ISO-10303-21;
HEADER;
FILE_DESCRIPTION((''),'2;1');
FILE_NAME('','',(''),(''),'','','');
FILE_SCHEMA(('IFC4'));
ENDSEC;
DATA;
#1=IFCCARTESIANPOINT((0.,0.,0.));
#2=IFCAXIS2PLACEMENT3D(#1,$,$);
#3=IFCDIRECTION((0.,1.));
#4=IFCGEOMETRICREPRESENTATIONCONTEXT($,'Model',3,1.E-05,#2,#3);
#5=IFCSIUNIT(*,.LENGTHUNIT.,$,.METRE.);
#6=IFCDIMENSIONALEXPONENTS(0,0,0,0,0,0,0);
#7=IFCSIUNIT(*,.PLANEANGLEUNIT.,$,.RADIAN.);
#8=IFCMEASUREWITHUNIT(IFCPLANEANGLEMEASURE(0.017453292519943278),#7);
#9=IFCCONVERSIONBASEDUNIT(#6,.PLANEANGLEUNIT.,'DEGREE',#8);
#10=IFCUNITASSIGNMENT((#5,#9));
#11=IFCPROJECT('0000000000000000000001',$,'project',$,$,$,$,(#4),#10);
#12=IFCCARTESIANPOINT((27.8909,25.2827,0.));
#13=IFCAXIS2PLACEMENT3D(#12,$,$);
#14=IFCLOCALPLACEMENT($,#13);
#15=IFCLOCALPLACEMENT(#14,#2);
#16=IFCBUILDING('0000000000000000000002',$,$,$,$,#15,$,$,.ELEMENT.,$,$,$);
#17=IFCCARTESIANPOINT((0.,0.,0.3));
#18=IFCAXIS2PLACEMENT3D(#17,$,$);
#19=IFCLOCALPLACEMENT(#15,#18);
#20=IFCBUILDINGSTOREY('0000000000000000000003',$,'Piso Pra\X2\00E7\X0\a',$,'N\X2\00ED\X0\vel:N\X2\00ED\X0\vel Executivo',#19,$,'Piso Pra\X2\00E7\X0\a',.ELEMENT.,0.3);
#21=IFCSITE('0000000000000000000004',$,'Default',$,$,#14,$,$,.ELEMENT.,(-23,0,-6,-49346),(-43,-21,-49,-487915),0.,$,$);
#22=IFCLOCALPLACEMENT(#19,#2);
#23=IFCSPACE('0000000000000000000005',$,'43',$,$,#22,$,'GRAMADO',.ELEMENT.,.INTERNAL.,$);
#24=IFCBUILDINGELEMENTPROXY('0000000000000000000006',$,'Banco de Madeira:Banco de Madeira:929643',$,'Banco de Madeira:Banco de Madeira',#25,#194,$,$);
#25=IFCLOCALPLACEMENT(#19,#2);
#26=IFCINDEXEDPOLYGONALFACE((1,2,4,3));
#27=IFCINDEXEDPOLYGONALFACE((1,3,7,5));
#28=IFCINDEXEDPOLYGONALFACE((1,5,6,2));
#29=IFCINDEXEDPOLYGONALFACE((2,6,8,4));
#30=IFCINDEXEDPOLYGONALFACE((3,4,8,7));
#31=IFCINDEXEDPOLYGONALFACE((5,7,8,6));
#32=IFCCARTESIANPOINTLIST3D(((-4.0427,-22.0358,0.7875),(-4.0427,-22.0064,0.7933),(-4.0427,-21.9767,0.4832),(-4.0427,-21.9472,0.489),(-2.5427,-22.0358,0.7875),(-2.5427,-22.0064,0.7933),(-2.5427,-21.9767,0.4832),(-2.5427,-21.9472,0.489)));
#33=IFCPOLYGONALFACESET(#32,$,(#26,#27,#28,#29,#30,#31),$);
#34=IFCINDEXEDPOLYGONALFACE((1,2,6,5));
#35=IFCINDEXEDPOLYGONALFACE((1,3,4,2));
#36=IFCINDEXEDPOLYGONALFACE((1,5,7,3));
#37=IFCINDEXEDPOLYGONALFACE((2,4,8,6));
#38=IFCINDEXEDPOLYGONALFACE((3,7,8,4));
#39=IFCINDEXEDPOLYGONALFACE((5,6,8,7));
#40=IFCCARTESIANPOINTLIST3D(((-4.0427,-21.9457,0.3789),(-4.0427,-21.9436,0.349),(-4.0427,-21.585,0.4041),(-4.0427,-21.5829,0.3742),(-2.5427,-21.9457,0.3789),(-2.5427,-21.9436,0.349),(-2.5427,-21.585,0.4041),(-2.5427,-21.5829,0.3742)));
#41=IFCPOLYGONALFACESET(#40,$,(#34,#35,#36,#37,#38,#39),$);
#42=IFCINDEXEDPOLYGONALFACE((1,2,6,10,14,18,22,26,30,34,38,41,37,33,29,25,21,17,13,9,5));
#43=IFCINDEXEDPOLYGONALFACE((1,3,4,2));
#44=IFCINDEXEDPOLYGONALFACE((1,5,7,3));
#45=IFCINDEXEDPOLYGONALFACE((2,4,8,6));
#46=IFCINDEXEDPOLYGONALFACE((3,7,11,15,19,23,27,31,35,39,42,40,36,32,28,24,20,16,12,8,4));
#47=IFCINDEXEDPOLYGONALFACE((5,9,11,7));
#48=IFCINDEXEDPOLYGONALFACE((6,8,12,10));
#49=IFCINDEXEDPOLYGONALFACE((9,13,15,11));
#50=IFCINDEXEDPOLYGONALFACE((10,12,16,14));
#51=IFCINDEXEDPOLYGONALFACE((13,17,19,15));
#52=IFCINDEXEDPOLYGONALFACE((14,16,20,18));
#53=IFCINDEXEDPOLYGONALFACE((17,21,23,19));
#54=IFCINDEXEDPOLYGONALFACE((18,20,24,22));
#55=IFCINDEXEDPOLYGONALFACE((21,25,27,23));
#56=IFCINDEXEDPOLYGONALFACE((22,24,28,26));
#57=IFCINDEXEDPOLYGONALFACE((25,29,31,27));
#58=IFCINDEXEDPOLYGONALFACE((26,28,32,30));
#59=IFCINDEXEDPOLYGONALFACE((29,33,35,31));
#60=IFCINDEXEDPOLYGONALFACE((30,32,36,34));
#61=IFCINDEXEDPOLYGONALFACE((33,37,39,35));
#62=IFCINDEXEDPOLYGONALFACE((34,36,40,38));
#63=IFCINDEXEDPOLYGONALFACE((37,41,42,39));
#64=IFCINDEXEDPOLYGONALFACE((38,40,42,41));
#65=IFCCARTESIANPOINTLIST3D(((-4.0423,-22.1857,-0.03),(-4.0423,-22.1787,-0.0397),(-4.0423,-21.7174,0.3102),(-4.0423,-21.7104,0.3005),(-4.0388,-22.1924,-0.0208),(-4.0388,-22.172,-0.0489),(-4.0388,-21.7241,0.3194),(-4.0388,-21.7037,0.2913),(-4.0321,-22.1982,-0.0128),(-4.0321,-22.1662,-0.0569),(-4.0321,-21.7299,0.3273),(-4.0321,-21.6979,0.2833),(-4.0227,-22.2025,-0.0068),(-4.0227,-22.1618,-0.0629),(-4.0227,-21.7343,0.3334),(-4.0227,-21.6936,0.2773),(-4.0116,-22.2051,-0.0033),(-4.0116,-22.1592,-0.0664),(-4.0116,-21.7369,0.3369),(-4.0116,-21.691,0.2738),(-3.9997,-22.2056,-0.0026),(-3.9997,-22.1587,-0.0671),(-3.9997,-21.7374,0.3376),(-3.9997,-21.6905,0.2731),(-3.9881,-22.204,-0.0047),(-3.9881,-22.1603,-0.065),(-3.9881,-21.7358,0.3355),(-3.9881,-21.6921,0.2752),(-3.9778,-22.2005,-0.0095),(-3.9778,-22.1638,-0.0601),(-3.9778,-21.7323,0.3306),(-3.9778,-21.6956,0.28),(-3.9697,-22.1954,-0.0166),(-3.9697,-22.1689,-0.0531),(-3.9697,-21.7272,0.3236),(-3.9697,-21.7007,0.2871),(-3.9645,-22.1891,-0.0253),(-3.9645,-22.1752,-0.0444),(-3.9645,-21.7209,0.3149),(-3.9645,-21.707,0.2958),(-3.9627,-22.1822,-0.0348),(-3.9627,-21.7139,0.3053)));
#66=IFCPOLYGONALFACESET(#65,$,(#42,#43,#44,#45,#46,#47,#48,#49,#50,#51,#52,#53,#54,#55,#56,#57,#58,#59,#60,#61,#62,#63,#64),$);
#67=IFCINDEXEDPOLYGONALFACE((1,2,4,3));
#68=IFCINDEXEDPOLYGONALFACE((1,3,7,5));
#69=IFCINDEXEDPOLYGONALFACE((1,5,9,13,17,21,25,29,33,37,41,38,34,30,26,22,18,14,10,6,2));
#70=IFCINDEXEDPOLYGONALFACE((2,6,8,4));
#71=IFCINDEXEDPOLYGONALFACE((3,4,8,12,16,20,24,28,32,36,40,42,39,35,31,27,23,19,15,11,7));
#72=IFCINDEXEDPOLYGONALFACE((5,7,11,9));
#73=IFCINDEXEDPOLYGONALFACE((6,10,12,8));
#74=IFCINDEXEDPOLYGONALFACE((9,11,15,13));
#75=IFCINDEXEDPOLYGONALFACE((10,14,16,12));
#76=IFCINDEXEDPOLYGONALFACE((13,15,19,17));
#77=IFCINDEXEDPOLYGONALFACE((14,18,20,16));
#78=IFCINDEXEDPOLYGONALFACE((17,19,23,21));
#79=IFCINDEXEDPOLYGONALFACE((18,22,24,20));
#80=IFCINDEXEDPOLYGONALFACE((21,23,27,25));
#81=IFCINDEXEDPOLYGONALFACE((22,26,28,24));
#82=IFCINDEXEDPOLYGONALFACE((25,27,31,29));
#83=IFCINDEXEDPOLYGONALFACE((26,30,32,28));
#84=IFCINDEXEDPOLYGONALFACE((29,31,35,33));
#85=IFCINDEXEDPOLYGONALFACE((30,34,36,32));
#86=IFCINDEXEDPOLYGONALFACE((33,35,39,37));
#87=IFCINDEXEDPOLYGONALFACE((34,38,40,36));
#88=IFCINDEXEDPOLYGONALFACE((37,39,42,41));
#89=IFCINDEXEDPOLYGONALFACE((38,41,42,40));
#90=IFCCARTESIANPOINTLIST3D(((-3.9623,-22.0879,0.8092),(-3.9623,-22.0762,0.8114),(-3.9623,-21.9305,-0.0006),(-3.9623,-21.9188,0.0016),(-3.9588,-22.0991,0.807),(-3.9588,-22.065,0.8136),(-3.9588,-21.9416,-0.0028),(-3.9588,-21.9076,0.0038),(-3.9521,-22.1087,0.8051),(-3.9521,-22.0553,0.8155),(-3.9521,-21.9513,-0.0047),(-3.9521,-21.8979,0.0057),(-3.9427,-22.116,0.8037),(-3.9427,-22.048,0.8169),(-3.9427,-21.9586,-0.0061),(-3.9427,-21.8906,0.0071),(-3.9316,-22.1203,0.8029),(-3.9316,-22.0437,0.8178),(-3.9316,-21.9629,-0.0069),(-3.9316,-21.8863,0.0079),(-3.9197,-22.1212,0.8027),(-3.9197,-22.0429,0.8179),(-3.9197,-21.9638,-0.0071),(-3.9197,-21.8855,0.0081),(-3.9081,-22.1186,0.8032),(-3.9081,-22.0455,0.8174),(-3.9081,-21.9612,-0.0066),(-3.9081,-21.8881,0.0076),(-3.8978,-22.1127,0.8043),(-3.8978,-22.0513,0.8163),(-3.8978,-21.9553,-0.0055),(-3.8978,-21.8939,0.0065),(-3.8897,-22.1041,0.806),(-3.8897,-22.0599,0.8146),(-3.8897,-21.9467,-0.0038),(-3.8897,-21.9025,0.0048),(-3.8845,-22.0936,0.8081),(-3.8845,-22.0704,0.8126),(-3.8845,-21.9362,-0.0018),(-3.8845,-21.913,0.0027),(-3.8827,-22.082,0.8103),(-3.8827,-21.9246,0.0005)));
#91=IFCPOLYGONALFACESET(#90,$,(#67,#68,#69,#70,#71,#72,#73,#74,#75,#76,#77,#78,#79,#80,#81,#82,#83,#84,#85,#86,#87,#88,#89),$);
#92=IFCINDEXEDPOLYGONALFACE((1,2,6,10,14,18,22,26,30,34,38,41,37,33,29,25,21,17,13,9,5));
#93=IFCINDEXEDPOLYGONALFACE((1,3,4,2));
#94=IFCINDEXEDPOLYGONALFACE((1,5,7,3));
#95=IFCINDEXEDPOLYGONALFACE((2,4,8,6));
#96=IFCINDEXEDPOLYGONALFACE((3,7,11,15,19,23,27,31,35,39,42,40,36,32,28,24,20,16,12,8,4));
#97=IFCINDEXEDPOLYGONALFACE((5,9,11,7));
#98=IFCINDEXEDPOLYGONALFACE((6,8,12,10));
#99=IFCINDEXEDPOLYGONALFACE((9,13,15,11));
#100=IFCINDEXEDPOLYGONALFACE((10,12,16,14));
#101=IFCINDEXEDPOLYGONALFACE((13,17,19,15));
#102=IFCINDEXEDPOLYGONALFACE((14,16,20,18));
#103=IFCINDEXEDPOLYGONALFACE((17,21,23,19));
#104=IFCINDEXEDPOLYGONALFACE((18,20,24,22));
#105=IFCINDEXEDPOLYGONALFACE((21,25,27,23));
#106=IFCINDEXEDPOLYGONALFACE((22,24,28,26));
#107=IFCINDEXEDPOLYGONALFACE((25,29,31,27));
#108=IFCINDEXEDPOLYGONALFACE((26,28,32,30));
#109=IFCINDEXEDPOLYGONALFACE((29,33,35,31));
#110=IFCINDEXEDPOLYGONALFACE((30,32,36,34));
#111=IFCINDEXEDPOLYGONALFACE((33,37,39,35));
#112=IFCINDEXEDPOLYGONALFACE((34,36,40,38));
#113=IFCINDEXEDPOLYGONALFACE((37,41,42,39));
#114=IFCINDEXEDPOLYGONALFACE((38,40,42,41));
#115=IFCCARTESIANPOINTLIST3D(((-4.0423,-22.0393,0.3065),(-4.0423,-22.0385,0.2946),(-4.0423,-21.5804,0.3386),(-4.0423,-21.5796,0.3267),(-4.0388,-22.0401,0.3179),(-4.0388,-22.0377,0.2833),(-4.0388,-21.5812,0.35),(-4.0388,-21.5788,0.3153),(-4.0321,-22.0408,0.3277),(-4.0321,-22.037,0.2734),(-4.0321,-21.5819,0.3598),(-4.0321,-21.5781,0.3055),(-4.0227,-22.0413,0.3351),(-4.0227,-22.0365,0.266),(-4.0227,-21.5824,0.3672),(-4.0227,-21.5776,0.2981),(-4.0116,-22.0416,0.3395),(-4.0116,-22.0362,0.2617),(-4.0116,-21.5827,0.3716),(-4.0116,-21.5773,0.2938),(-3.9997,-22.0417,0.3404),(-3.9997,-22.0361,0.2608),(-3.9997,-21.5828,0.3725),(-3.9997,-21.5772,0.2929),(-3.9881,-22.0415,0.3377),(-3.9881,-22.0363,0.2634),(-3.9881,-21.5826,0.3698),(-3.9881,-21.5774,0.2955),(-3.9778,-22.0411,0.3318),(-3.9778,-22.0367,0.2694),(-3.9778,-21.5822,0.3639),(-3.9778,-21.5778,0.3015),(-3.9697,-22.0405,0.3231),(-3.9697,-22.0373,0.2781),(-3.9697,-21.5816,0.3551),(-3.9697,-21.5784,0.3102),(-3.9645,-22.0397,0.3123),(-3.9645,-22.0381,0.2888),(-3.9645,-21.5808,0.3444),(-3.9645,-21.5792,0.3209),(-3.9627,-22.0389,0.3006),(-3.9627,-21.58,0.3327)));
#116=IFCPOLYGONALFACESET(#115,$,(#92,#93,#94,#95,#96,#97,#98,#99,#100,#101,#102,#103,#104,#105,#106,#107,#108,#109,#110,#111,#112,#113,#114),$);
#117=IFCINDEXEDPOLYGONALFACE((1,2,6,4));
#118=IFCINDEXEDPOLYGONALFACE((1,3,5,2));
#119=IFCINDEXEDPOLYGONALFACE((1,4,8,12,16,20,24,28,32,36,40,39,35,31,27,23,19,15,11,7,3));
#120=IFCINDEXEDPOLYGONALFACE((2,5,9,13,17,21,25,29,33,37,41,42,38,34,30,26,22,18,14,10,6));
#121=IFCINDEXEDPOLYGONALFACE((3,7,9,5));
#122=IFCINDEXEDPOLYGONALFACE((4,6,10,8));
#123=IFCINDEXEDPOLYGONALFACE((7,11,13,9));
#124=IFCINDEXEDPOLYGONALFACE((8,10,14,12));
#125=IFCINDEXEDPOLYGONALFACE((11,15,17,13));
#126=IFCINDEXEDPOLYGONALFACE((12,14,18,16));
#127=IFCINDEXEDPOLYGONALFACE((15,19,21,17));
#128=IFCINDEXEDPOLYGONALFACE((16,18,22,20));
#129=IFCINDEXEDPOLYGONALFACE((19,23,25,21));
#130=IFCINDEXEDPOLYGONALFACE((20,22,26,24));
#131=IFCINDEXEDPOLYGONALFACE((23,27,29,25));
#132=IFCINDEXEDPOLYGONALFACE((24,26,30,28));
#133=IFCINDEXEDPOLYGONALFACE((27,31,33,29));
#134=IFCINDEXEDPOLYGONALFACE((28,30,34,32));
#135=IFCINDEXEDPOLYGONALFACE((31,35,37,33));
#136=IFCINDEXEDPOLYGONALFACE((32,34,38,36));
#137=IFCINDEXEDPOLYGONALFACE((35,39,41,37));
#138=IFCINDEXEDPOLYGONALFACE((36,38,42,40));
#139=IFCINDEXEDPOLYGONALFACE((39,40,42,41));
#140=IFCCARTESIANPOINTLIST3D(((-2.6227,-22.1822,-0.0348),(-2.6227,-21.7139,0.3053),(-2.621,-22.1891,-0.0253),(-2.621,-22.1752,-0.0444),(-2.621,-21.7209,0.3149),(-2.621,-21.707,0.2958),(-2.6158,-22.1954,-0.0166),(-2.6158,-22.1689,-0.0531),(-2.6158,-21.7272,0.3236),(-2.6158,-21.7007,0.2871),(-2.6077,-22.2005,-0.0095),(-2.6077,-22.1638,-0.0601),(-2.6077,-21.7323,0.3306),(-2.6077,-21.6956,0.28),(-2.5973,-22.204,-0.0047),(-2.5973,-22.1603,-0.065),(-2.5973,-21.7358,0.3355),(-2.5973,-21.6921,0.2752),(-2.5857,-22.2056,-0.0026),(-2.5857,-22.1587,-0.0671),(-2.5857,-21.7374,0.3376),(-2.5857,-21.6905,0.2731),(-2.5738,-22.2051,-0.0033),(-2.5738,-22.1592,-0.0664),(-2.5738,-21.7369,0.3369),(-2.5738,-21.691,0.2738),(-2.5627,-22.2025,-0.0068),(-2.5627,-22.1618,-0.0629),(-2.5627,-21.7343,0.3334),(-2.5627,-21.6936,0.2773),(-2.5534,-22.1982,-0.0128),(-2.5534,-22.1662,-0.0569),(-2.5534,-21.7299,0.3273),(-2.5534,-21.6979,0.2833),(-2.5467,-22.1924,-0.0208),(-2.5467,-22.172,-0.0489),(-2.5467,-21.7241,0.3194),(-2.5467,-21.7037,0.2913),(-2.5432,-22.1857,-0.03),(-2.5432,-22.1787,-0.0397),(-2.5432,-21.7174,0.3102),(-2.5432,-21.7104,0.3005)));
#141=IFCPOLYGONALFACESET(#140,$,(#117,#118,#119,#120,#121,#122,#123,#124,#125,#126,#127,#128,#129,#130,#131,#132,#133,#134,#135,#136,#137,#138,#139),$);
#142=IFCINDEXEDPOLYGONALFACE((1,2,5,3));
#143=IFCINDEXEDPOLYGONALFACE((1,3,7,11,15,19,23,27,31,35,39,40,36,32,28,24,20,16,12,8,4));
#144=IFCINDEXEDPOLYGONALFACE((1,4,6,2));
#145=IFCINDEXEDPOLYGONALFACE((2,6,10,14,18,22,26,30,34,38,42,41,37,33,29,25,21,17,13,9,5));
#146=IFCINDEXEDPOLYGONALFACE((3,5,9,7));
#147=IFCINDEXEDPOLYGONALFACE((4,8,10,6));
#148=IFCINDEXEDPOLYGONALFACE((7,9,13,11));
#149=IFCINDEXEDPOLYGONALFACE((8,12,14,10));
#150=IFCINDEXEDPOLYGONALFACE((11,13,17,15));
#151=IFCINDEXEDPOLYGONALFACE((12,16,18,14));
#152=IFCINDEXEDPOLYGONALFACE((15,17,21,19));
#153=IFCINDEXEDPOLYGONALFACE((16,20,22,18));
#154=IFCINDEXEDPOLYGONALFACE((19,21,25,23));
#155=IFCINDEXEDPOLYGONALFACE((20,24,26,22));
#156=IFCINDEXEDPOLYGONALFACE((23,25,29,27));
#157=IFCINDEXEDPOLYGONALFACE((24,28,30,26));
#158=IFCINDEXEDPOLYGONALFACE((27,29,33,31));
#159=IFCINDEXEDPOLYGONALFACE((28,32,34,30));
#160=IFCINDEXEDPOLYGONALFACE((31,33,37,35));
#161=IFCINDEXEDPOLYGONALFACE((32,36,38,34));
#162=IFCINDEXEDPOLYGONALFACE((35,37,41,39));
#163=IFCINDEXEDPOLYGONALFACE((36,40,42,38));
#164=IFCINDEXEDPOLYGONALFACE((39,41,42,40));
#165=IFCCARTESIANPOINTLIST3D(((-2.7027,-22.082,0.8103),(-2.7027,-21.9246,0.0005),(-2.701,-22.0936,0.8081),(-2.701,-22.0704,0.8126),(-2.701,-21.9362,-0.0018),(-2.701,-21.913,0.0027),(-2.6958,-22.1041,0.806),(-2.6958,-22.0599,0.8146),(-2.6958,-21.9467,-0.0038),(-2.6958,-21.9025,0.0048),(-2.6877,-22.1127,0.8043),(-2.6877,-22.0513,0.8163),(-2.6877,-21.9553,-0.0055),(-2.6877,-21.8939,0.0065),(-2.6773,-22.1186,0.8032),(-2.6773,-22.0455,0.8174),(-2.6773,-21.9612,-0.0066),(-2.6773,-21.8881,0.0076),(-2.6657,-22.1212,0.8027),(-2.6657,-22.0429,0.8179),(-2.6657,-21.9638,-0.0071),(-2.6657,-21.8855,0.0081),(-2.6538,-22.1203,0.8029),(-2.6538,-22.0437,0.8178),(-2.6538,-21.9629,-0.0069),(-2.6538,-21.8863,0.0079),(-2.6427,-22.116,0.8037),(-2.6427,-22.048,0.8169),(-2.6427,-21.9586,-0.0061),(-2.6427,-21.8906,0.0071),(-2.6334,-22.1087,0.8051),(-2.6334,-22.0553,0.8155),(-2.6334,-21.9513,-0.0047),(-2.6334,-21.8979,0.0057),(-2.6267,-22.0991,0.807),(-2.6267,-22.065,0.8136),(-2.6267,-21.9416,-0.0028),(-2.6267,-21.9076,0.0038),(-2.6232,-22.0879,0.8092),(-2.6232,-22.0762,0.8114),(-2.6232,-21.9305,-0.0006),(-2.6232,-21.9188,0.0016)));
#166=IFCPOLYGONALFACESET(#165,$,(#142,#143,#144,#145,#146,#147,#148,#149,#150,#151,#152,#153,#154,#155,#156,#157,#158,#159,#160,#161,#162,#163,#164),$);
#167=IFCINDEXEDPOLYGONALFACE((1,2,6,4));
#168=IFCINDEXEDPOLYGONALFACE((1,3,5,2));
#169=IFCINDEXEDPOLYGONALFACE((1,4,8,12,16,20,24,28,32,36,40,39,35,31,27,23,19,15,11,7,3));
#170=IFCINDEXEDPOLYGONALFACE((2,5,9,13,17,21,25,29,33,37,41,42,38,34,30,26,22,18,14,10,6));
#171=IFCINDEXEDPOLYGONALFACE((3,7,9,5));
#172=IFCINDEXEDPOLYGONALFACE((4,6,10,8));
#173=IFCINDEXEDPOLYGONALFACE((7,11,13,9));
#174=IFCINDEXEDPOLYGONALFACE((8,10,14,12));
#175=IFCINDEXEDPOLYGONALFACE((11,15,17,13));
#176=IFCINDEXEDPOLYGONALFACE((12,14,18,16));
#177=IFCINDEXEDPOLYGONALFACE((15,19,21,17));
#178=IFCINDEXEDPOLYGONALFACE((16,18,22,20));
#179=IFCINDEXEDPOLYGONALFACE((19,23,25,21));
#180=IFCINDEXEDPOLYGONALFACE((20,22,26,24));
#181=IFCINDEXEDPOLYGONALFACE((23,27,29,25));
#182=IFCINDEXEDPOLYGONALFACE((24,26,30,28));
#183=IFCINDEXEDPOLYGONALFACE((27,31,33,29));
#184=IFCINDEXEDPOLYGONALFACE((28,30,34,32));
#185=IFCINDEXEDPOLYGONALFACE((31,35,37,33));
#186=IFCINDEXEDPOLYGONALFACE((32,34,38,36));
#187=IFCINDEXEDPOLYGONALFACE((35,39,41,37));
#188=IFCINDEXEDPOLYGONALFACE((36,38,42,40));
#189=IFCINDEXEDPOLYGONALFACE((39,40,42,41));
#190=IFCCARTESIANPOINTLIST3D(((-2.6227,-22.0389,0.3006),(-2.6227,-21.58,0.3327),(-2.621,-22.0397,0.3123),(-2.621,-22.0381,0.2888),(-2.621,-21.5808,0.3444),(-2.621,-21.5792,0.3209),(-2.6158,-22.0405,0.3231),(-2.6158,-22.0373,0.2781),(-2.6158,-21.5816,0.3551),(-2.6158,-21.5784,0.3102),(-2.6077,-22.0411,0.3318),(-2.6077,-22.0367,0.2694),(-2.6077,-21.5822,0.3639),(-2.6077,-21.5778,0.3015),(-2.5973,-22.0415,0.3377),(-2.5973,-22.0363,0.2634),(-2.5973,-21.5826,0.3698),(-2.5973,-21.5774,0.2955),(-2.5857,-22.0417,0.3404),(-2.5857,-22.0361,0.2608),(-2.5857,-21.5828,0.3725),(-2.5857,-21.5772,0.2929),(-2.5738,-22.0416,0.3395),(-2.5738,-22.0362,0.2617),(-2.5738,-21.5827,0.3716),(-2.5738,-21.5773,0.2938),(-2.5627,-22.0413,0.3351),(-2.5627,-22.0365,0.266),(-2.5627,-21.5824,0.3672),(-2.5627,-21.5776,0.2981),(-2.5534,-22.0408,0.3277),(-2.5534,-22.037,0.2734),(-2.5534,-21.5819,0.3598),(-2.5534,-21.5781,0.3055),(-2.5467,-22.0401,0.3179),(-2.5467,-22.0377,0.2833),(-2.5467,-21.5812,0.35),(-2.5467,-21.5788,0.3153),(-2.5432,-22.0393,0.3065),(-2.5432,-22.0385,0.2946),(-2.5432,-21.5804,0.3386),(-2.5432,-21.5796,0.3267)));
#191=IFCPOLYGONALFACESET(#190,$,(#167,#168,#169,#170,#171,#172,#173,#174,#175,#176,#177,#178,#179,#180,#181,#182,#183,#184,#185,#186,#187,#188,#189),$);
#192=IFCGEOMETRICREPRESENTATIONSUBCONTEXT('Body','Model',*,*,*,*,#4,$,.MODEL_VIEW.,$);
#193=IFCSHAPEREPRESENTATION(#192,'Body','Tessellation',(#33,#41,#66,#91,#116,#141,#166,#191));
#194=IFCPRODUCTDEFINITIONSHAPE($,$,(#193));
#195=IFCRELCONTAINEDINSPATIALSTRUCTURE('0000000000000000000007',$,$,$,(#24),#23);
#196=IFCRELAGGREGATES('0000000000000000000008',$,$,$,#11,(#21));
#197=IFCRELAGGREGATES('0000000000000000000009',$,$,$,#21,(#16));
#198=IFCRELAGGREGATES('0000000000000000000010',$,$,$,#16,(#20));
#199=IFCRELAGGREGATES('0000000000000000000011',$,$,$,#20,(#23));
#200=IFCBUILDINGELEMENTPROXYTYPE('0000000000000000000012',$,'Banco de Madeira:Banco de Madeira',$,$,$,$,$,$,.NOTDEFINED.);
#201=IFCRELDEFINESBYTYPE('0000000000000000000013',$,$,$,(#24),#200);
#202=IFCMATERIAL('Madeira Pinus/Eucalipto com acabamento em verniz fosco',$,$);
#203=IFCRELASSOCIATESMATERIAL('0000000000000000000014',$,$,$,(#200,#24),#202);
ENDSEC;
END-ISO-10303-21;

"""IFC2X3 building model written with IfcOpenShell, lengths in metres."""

from ifc_helpers import new_model, entity, si_unit, converted_unit, direction, frame, frame_2d, origin, place, context, subcontext, project, spatial, rectangle, circle, extrude, source, transform, mapped, material, type_object, type_shapes, element, save


model = new_model("IFC2X3")

# Units and contexts
model_context = context("Model", 3, precision=1e-05, world=origin(), true_north=direction((0.0, 1.0)))
body_context = subcontext(model_context, "Body", "Model", "MODEL_VIEW")
ifc_project = project(units=[si_unit("LENGTHUNIT", "METRE"), converted_unit("PLANEANGLEUNIT", "DEGREE", entity("IfcPlaneAngleMeasure", 0.017453292519943278), si_unit("PLANEANGLEUNIT", "RADIAN"), dimensions=[0, 0, 0, 0, 0, 0, 0])], contexts=[model_context])

# Site, building, storey
site_placement = place(None, frame((27.8909, 25.2827, 0.0)))
site = spatial("IfcSite", under=ifc_project, at=site_placement, Name="Default", CompositionType="ELEMENT", RefLatitude=(-23, 0, -6, -49346), RefLongitude=(-43, -21, -49, -487915), RefElevation=0.0)
building_placement = place(site_placement, origin())
building = spatial("IfcBuilding", under=site, at=building_placement, CompositionType="ELEMENT")
storey_placement = place(building_placement, frame((0.0, 0.0, 0.3)))
storey = spatial("IfcBuildingStorey", under=building, at=storey_placement, Name="Piso Praça", ObjectType="Nível:Nível Executivo", LongName="Piso Praça", CompositionType="ELEMENT", Elevation=0.3)

# Shared definitions
space_1_placement = place(storey_placement, origin())
space_1 = spatial("IfcSpace", under=storey, at=space_1_placement, Name="43", LongName="GRAMADO", CompositionType="ELEMENT", InteriorOrExteriorSpace="INTERNAL")

# Building element proxy
ifc_material_1 = material(Name="Madeira Pinus/Eucalipto com acabamento em verniz fosco")
building_element_proxy_type_1 = type_object("IfcBuildingElementProxyType", Name="Banco de Madeira:Banco de Madeira", PredefinedType="NOTDEFINED", material=ifc_material_1)
shared_shape_1 = source(origin(), body_context, "Body", "SweptSolid", [
    extrude(rectangle(XDim=0.31, YDim=0.03, at=frame_2d((0.0, 0.0), x_axis=(1.0, 0.0))), frame((-0.75, 0.1439, 0.6383), z_axis=(1.0, 0.0, 0.0), x_axis=(0.0, 0.190809, 0.981627)), (0.0, 0.0, 1.0), 1.5),
    extrude(rectangle(XDim=0.03, YDim=0.3616, at=frame_2d((0.0, 0.0), x_axis=(0.0, 1.0))), frame((-0.75, -0.0833, 0.3765), z_axis=(1.0, 0.0, 0.0), x_axis=(0.0, 0.997564, -0.069756)), (0.0, 0.0, 1.0), 1.5),
    extrude(circle(Radius=0.04, at=frame_2d((0.0, 0.0), x_axis=(1.0, 0.0))), frame((0.71, 0.3345, -0.0348), z_axis=(0.0, -0.809017, 0.587785), x_axis=(-1.0, 0.0, 0.0)), (0.0, 0.0, 1.0), 0.5788),
    extrude(circle(Radius=0.04, at=frame_2d((0.0, 0.0), x_axis=(1.0, 0.0))), frame((0.63, 0.077, 0.0005), z_axis=(0.0, 0.190809, 0.981627), x_axis=(-1.0, 0.0, 0.0)), (0.0, 0.0, 1.0), 0.825),
    extrude(circle(Radius=0.04, at=frame_2d((0.0, 0.0), x_axis=(1.0, 0.0))), frame((0.71, -0.2676, 0.3327), z_axis=(0.0, 0.997564, -0.069756), x_axis=(-1.0, 0.0, 0.0)), (0.0, 0.0, 1.0), 0.46),
    extrude(circle(Radius=0.04, at=frame_2d((0.0, 0.0), x_axis=(1.0, 0.0))), frame((-0.71, 0.3345, -0.0348), z_axis=(0.0, -0.809017, 0.587785), x_axis=(1.0, 0.0, 0.0)), (0.0, 0.0, 1.0), 0.5788),
    extrude(circle(Radius=0.04, at=frame_2d((0.0, 0.0), x_axis=(1.0, 0.0))), frame((-0.63, 0.077, 0.0005), z_axis=(0.0, 0.190809, 0.981627), x_axis=(1.0, 0.0, 0.0)), (0.0, 0.0, 1.0), 0.825),
    extrude(circle(Radius=0.04, at=frame_2d((0.0, 0.0), x_axis=(1.0, 0.0))), frame((-0.71, -0.2676, 0.3327), z_axis=(0.0, 0.997564, -0.069756), x_axis=(1.0, 0.0, 0.0)), (0.0, 0.0, 1.0), 0.46),
])
type_shapes(building_element_proxy_type_1, [shared_shape_1])
for number, where, z_axis, x_axis, name in (
    (1, (-3.2927, -21.8476, 0.0), (0.0, 0.0, 1.0), (-1.0, 0.0, 0.0), "Banco de Madeira:Banco de Madeira:929643"),
):
    element("IfcBuildingElementProxy", number, at=place(space_1_placement, frame(where, z_axis=z_axis, x_axis=x_axis)), inside=space_1, type_object=building_element_proxy_type_1, material=ifc_material_1, Name=name, ObjectType="Banco de Madeira:Banco de Madeira", context=body_context, shape_type="MappedRepresentation", body=[
        mapped(shared_shape_1, transform((0.0, 0.0, 0.0), scale=1.0)),
    ])

save(model, "model.ifc")
